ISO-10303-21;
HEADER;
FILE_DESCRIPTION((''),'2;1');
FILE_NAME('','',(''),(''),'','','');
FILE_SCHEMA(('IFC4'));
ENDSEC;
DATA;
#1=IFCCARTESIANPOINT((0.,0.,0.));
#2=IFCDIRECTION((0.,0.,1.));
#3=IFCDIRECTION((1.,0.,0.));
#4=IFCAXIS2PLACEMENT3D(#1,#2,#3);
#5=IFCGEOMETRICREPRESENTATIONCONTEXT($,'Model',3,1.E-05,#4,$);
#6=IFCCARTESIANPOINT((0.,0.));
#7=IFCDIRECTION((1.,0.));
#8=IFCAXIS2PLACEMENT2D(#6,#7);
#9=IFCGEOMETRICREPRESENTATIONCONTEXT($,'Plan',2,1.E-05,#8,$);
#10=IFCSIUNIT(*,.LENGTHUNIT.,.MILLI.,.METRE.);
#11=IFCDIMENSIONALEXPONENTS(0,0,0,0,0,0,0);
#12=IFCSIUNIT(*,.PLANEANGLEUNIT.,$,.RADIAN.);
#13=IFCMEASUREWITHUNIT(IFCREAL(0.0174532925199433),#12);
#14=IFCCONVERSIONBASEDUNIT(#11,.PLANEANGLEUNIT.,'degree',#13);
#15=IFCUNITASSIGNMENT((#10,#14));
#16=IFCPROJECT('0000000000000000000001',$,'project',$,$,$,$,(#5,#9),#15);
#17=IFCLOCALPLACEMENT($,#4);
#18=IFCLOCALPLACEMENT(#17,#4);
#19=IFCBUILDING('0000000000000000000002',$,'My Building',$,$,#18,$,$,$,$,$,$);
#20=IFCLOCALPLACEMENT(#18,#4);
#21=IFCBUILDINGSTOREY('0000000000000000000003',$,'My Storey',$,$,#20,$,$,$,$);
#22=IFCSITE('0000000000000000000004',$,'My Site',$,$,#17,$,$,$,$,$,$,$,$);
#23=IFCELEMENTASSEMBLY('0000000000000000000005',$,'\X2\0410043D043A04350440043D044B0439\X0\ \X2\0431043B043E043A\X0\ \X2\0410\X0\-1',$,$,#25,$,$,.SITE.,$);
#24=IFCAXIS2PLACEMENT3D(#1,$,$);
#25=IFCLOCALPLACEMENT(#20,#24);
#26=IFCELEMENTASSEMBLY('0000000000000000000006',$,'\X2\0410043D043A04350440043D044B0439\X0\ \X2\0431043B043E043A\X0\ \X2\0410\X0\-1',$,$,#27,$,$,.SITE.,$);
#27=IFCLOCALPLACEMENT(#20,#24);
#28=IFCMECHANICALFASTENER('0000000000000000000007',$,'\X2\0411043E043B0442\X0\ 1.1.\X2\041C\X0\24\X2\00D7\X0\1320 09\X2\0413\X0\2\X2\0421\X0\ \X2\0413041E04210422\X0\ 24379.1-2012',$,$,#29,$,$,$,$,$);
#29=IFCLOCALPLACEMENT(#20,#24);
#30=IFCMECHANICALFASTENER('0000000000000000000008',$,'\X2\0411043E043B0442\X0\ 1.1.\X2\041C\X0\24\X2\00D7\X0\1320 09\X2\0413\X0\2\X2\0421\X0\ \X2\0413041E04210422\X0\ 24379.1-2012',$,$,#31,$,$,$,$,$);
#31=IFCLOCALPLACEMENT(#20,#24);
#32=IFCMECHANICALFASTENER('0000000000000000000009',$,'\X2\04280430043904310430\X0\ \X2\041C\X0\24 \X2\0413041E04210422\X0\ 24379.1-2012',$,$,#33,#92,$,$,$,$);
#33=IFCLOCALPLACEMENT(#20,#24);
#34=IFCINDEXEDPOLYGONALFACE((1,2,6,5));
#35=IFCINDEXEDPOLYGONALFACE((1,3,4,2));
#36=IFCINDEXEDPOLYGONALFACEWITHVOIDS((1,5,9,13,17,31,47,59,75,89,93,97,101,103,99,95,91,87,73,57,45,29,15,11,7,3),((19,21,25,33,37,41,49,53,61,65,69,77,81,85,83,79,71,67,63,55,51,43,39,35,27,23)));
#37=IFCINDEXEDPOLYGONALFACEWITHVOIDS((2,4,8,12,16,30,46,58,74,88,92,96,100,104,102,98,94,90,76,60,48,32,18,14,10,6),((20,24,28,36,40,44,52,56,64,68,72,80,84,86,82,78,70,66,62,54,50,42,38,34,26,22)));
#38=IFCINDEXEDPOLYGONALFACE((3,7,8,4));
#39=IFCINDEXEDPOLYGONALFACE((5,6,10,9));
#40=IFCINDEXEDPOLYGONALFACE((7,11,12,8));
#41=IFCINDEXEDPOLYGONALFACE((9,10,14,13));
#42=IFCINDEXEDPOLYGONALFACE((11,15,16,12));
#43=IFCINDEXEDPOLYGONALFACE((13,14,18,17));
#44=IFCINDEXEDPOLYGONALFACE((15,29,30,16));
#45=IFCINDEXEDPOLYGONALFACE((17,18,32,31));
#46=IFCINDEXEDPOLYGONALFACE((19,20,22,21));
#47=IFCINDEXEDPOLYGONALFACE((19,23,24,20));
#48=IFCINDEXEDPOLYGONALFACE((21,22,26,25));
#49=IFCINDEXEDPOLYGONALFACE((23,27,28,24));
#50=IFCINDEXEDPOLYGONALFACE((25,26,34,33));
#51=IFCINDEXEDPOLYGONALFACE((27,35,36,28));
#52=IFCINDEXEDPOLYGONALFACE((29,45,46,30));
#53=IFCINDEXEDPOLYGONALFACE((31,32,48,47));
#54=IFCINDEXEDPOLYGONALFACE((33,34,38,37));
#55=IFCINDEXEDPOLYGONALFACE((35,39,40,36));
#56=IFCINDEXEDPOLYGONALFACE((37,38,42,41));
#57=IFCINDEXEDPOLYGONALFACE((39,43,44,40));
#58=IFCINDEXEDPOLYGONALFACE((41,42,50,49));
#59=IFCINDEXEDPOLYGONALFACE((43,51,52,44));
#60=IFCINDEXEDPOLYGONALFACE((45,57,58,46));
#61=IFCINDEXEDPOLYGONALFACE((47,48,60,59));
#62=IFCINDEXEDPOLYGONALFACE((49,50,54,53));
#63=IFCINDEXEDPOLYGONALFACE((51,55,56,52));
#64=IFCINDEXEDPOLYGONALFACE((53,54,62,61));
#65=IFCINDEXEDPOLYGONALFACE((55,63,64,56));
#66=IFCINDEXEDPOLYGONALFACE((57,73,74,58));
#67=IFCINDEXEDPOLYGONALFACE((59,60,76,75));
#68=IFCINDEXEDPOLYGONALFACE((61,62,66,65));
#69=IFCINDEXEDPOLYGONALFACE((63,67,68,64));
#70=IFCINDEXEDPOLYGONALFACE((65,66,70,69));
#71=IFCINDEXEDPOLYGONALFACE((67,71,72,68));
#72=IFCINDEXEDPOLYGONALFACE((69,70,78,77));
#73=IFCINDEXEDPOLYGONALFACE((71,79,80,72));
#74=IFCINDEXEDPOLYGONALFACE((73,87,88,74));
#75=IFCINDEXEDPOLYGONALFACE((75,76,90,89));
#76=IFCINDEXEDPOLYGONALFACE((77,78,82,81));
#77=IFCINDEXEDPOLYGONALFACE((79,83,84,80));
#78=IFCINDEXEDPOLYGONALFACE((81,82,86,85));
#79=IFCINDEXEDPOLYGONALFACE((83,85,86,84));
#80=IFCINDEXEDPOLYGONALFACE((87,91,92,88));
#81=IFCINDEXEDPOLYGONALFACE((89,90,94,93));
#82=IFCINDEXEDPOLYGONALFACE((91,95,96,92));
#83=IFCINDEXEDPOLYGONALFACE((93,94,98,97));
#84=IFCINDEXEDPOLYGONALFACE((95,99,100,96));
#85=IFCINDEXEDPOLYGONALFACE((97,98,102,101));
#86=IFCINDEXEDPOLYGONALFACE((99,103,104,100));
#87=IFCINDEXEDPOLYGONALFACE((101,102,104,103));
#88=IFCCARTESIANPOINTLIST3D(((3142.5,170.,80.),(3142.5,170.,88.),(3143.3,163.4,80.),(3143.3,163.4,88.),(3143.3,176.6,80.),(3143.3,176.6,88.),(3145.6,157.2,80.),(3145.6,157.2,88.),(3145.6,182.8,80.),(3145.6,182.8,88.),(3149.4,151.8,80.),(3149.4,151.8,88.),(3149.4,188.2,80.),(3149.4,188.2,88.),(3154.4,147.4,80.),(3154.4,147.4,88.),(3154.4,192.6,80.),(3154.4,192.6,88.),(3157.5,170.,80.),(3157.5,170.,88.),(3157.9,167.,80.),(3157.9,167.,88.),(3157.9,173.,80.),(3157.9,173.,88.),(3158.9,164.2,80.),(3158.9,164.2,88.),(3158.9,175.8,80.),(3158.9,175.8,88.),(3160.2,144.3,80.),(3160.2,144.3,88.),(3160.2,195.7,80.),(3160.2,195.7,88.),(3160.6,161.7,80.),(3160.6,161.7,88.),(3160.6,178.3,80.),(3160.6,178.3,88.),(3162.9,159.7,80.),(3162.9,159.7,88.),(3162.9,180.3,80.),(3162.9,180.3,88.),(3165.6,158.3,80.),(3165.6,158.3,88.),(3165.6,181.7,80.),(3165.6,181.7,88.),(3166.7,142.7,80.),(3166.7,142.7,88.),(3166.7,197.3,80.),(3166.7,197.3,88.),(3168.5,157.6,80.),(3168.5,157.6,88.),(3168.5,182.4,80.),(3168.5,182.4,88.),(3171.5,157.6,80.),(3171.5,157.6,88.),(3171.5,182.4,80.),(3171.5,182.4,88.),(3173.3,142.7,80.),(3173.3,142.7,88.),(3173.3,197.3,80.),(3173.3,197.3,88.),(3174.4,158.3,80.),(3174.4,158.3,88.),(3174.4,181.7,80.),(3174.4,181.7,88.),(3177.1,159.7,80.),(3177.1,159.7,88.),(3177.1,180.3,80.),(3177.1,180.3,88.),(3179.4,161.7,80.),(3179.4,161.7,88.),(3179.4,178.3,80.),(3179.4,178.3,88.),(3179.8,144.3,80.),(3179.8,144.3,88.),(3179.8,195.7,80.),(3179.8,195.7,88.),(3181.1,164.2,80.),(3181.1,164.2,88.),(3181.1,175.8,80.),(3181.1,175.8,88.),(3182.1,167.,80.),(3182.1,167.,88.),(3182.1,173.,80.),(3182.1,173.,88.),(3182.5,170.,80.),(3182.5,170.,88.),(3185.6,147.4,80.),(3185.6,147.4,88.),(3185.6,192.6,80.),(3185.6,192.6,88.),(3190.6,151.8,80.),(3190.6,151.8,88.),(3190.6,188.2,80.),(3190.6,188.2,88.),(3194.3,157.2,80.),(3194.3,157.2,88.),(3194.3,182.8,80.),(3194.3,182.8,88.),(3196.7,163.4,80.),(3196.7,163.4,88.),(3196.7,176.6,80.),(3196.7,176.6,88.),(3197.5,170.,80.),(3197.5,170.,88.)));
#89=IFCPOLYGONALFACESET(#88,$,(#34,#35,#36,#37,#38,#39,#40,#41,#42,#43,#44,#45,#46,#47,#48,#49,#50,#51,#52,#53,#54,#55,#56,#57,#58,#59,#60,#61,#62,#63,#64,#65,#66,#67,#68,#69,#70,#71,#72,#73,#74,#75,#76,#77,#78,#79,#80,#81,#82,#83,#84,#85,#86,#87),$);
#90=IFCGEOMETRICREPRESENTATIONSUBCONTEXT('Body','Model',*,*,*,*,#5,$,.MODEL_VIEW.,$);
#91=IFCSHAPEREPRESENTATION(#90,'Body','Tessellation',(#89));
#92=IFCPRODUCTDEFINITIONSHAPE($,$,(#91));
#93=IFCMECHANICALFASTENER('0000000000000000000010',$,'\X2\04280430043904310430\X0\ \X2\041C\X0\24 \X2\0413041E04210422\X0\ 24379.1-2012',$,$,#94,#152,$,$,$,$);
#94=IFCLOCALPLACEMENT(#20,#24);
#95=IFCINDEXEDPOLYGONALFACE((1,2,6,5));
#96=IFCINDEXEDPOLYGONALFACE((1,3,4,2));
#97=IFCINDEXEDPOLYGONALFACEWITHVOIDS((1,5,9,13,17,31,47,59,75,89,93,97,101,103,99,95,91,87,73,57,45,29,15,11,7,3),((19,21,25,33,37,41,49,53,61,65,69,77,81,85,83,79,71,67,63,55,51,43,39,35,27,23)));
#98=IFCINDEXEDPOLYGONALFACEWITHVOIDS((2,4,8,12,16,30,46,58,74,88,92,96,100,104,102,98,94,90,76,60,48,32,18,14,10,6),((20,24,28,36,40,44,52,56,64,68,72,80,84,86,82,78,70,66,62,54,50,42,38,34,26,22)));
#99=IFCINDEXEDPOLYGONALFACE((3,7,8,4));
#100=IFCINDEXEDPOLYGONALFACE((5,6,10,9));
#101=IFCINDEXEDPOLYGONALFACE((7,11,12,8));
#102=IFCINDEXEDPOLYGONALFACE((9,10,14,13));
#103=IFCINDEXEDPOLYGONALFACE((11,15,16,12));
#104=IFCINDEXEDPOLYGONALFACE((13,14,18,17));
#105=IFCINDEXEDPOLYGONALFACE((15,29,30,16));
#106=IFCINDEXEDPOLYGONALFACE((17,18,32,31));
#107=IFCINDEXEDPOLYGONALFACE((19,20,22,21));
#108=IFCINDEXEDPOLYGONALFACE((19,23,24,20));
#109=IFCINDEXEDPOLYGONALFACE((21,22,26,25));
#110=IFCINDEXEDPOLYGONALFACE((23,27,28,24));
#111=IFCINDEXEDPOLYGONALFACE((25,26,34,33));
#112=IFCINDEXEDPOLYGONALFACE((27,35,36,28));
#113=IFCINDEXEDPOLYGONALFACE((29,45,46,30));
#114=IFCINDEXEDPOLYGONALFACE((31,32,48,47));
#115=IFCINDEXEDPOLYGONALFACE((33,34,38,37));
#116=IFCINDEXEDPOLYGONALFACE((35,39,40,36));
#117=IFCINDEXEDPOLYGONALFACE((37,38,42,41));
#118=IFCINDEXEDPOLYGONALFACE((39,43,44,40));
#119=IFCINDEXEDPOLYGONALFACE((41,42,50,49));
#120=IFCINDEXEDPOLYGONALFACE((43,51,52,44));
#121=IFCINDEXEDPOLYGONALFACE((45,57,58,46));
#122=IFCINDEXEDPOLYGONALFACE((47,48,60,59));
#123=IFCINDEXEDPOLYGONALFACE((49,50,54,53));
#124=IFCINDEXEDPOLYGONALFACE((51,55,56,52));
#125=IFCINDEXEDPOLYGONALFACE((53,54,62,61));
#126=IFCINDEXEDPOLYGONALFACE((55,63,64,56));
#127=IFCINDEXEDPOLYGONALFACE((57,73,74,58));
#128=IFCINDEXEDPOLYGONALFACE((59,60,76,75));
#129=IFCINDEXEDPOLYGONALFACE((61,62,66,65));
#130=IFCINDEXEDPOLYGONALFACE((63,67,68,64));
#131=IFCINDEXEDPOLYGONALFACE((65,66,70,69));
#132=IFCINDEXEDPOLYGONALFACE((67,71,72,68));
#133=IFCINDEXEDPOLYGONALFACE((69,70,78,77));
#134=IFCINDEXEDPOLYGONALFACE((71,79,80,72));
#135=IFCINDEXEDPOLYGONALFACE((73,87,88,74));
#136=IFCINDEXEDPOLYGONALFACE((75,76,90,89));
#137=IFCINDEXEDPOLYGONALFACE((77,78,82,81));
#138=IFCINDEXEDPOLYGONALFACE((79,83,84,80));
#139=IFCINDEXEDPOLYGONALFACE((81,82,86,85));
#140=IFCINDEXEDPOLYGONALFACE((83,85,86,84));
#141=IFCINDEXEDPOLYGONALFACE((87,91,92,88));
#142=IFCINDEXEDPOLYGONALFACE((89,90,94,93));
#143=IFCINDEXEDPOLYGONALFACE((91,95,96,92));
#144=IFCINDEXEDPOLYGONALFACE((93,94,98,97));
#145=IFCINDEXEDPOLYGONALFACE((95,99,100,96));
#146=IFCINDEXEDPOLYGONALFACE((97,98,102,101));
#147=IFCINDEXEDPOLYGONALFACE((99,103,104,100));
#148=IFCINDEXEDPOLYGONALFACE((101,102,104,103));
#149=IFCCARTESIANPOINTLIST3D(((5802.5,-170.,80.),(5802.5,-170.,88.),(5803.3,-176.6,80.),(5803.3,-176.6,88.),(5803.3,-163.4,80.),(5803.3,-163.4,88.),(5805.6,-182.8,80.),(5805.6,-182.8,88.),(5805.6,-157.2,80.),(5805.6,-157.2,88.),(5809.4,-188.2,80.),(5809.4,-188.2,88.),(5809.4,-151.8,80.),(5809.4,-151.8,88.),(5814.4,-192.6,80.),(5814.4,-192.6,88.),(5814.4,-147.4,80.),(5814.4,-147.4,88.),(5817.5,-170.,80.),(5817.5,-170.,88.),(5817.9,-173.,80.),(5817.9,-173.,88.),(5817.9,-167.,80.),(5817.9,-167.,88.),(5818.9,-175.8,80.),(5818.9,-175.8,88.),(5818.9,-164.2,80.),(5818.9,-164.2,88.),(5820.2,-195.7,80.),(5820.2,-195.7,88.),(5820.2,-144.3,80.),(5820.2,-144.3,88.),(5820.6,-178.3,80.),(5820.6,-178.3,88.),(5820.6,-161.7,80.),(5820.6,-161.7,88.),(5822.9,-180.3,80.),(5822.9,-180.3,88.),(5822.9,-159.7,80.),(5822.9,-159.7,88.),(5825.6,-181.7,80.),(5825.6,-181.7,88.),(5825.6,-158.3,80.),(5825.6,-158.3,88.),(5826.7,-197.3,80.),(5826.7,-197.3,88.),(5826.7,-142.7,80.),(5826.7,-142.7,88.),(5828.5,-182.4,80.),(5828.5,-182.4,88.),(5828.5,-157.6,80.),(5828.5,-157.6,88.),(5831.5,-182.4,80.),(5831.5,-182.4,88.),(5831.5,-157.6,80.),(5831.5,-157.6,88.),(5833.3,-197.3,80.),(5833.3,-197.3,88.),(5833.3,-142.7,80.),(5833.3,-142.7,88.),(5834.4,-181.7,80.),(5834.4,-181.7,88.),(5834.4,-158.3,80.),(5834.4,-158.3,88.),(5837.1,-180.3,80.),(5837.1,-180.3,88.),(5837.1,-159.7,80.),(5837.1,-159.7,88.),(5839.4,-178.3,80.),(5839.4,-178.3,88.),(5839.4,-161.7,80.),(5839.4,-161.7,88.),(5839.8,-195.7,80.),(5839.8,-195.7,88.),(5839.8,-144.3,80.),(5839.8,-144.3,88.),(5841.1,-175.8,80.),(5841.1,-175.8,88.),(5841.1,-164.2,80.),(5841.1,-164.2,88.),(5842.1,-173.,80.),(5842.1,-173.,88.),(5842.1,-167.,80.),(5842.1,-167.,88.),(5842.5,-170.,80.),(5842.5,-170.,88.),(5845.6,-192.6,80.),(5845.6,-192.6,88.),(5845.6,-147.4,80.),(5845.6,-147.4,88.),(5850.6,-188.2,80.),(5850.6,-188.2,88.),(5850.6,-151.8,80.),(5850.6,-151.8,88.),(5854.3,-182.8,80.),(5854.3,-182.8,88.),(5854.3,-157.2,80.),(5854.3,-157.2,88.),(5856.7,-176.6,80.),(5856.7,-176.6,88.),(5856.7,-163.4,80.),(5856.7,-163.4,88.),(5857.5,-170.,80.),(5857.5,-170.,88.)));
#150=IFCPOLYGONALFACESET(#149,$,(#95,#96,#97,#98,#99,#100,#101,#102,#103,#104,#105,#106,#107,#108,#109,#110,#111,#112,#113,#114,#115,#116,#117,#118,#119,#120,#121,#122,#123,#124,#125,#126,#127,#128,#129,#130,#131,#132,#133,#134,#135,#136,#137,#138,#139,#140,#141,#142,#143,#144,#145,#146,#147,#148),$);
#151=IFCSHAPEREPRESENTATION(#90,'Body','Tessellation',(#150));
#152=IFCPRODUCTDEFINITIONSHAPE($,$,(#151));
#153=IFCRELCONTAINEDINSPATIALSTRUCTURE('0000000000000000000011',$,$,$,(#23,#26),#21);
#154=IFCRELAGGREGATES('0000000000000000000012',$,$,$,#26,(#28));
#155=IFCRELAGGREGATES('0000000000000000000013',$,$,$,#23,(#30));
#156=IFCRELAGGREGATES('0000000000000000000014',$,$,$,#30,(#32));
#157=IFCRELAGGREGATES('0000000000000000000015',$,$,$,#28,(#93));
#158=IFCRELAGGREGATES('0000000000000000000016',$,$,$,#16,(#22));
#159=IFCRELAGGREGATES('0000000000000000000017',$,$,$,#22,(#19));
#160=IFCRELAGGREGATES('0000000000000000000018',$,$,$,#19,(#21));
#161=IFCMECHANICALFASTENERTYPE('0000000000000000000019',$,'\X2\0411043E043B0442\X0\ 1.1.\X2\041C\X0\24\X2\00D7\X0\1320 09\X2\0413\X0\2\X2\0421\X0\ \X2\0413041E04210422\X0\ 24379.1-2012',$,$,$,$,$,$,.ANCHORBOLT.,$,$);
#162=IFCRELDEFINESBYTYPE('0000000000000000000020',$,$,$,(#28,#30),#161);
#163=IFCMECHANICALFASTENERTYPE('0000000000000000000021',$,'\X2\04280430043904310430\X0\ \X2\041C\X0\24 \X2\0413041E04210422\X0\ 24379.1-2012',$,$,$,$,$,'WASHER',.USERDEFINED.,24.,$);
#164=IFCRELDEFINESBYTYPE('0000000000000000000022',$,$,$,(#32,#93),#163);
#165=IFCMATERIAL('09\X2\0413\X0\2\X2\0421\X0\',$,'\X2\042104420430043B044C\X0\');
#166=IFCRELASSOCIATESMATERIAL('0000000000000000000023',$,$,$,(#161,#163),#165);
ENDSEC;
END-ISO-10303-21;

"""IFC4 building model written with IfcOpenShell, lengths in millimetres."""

from ifc_helpers import new_model, entity, si_unit, converted_unit, frame, origin_with_axes, origin_2d_with_axis, place, context, subcontext, project, spatial, polyline, outline, extrude, source, transform, mapped, material, type_object, type_shapes, element, aggregate, save


model = new_model("IFC4")

# Units and contexts
model_context = context("Model", 3, precision=1e-05, world=origin_with_axes())
plan_context = context("Plan", 2, precision=1e-05, world=origin_2d_with_axis())
body_context = subcontext(model_context, "Body", "Model", "MODEL_VIEW")
ifc_project = project(units=[si_unit("LENGTHUNIT", "METRE", prefix="MILLI"), converted_unit("PLANEANGLEUNIT", "degree", entity("IfcReal", 0.0174532925199433), si_unit("PLANEANGLEUNIT", "RADIAN"), dimensions=[0, 0, 0, 0, 0, 0, 0])], contexts=[model_context, plan_context])

# Site, building, storey
site_placement = place(None, origin_with_axes())
site = spatial("IfcSite", under=ifc_project, at=site_placement, Name="My Site")
building_placement = place(site_placement, origin_with_axes())
building = spatial("IfcBuilding", under=site, at=building_placement, Name="My Building")
storey_placement = place(building_placement, origin_with_axes())
storey = spatial("IfcBuildingStorey", under=building, at=storey_placement, Name="My Storey")

# Element assembly
assembly_1_placement = place(storey_placement, frame((3000.0, 0.0, 0.0), z_axis=(0.0, 0.0, 1.0), x_axis=(1.0, 0.0, 0.0)))
assembly_1 = element("IfcElementAssembly", 1, at=assembly_1_placement, inside=storey, Name="Анкерный блок А-1", AssemblyPlace="SITE")

# Element assembly, mechanical fastener
assembly_2_placement = place(storey_placement, frame((6000.0, 0.0, 0.0), z_axis=(0.0, 0.0, 1.0), x_axis=(1.0, 0.0, 0.0)))
assembly_2 = element("IfcElementAssembly", 2, at=assembly_2_placement, inside=storey, Name="Анкерный блок А-1", AssemblyPlace="SITE")
ifc_material_1 = material(Name="09Г2С", Category="Сталь")
mechanical_fastener_type_1 = type_object("IfcMechanicalFastenerType", Name="Болт 1.1.М24×1320 09Г2С ГОСТ 24379.1-2012", PredefinedType="ANCHORBOLT", material=ifc_material_1)
mechanical_fastener_1_placement = place(assembly_2_placement, frame((-170.0, -170.0, 0.0), z_axis=(0.0, 0.0, 1.0), x_axis=(1.0, 0.0, 0.0)))
mechanical_fastener_1 = element("IfcMechanicalFastener", 3, at=mechanical_fastener_1_placement, type_object=mechanical_fastener_type_1, Name="Болт 1.1.М24×1320 09Г2С ГОСТ 24379.1-2012")
aggregate(assembly_2, [mechanical_fastener_1])

# Mechanical fasteners
mechanical_fastener_2_placement = place(assembly_1_placement, frame((170.0, 170.0, 0.0), z_axis=(0.0, 0.0, 1.0), x_axis=(-1.0, 0.0, 0.0)))
mechanical_fastener_2 = element("IfcMechanicalFastener", 4, at=mechanical_fastener_2_placement, type_object=mechanical_fastener_type_1, Name="Болт 1.1.М24×1320 09Г2С ГОСТ 24379.1-2012")
aggregate(assembly_1, [mechanical_fastener_2])
mechanical_fastener_type_2 = type_object("IfcMechanicalFastenerType", Name="Шайба М24 ГОСТ 24379.1-2012", ElementType="WASHER", NominalDiameter=24.0, PredefinedType="USERDEFINED", material=ifc_material_1)
shared_shape_1 = source(origin_with_axes(), body_context, "Body", "SweptSolid", [
    extrude(outline(polyline([(27.5, 0.0), (26.7, 6.6), (24.4, 12.8), (20.6, 18.2), (15.6, 22.6), (9.8, 25.7), (3.3, 27.3), (-3.3, 27.3), (-9.8, 25.7), (-15.6, 22.6), (-20.6, 18.2), (-24.4, 12.8), (-26.7, 6.6), (-27.5, 0.0), (-26.7, -6.6), (-24.4, -12.8), (-20.6, -18.2), (-15.6, -22.6), (-9.8, -25.7), (-3.3, -27.3), (3.3, -27.3), (9.8, -25.7), (15.6, -22.6), (20.6, -18.2), (24.4, -12.8), (26.7, -6.6), (27.5, 0.0)]), holes=[polyline([(-4.4, -11.7), (-7.1, -10.3), (-9.4, -8.3), (-11.1, -5.8), (-12.1, -3.0), (-12.5, 0.0), (-12.1, 3.0), (-11.1, 5.8), (-9.4, 8.3), (-7.1, 10.3), (-4.4, 11.7), (-1.5, 12.4), (1.5, 12.4), (4.4, 11.7), (7.1, 10.3), (9.4, 8.3), (11.1, 5.8), (12.1, 3.0), (12.5, 0.0), (12.1, -3.0), (11.1, -5.8), (9.4, -8.3), (7.1, -10.3), (4.4, -11.7), (1.5, -12.4), (-1.5, -12.4), (-4.4, -11.7)])]), frame((0.0, 0.0, 0.0), z_axis=(0.0, 0.0, 1.0), x_axis=(0.120537, -0.992709, 0.0)), (0.0, 0.0, 1.0), 8.0),
])
type_shapes(mechanical_fastener_type_2, [shared_shape_1])
mechanical_fastener_3_placement = place(mechanical_fastener_2_placement, frame((0.0, 0.0, 80.0), z_axis=(0.0, 0.0, 1.0), x_axis=(1.0, 0.0, 0.0)))
mechanical_fastener_3 = element("IfcMechanicalFastener", 5, at=mechanical_fastener_3_placement, type_object=mechanical_fastener_type_2, Name="Шайба М24 ГОСТ 24379.1-2012", context=body_context, shape_type="MappedRepresentation", body=[
    mapped(shared_shape_1, transform((0.0, 0.0, 0.0), x_axis=(1.0, 0.0, 0.0), y_axis=(0.0, 1.0, 0.0), z_axis=(0.0, 0.0, 1.0), scale=1.0)),
])
aggregate(mechanical_fastener_2, [mechanical_fastener_3])
mechanical_fastener_4_placement = place(mechanical_fastener_1_placement, frame((0.0, 0.0, 80.0), z_axis=(0.0, 0.0, 1.0), x_axis=(1.0, 0.0, 0.0)))
mechanical_fastener_4 = element("IfcMechanicalFastener", 6, at=mechanical_fastener_4_placement, type_object=mechanical_fastener_type_2, Name="Шайба М24 ГОСТ 24379.1-2012", context=body_context, shape_type="MappedRepresentation", body=[
    mapped(shared_shape_1, transform((0.0, 0.0, 0.0), x_axis=(1.0, 0.0, 0.0), y_axis=(0.0, 1.0, 0.0), z_axis=(0.0, 0.0, 1.0), scale=1.0)),
])
aggregate(mechanical_fastener_1, [mechanical_fastener_4])

save(model, "model.ifc")
